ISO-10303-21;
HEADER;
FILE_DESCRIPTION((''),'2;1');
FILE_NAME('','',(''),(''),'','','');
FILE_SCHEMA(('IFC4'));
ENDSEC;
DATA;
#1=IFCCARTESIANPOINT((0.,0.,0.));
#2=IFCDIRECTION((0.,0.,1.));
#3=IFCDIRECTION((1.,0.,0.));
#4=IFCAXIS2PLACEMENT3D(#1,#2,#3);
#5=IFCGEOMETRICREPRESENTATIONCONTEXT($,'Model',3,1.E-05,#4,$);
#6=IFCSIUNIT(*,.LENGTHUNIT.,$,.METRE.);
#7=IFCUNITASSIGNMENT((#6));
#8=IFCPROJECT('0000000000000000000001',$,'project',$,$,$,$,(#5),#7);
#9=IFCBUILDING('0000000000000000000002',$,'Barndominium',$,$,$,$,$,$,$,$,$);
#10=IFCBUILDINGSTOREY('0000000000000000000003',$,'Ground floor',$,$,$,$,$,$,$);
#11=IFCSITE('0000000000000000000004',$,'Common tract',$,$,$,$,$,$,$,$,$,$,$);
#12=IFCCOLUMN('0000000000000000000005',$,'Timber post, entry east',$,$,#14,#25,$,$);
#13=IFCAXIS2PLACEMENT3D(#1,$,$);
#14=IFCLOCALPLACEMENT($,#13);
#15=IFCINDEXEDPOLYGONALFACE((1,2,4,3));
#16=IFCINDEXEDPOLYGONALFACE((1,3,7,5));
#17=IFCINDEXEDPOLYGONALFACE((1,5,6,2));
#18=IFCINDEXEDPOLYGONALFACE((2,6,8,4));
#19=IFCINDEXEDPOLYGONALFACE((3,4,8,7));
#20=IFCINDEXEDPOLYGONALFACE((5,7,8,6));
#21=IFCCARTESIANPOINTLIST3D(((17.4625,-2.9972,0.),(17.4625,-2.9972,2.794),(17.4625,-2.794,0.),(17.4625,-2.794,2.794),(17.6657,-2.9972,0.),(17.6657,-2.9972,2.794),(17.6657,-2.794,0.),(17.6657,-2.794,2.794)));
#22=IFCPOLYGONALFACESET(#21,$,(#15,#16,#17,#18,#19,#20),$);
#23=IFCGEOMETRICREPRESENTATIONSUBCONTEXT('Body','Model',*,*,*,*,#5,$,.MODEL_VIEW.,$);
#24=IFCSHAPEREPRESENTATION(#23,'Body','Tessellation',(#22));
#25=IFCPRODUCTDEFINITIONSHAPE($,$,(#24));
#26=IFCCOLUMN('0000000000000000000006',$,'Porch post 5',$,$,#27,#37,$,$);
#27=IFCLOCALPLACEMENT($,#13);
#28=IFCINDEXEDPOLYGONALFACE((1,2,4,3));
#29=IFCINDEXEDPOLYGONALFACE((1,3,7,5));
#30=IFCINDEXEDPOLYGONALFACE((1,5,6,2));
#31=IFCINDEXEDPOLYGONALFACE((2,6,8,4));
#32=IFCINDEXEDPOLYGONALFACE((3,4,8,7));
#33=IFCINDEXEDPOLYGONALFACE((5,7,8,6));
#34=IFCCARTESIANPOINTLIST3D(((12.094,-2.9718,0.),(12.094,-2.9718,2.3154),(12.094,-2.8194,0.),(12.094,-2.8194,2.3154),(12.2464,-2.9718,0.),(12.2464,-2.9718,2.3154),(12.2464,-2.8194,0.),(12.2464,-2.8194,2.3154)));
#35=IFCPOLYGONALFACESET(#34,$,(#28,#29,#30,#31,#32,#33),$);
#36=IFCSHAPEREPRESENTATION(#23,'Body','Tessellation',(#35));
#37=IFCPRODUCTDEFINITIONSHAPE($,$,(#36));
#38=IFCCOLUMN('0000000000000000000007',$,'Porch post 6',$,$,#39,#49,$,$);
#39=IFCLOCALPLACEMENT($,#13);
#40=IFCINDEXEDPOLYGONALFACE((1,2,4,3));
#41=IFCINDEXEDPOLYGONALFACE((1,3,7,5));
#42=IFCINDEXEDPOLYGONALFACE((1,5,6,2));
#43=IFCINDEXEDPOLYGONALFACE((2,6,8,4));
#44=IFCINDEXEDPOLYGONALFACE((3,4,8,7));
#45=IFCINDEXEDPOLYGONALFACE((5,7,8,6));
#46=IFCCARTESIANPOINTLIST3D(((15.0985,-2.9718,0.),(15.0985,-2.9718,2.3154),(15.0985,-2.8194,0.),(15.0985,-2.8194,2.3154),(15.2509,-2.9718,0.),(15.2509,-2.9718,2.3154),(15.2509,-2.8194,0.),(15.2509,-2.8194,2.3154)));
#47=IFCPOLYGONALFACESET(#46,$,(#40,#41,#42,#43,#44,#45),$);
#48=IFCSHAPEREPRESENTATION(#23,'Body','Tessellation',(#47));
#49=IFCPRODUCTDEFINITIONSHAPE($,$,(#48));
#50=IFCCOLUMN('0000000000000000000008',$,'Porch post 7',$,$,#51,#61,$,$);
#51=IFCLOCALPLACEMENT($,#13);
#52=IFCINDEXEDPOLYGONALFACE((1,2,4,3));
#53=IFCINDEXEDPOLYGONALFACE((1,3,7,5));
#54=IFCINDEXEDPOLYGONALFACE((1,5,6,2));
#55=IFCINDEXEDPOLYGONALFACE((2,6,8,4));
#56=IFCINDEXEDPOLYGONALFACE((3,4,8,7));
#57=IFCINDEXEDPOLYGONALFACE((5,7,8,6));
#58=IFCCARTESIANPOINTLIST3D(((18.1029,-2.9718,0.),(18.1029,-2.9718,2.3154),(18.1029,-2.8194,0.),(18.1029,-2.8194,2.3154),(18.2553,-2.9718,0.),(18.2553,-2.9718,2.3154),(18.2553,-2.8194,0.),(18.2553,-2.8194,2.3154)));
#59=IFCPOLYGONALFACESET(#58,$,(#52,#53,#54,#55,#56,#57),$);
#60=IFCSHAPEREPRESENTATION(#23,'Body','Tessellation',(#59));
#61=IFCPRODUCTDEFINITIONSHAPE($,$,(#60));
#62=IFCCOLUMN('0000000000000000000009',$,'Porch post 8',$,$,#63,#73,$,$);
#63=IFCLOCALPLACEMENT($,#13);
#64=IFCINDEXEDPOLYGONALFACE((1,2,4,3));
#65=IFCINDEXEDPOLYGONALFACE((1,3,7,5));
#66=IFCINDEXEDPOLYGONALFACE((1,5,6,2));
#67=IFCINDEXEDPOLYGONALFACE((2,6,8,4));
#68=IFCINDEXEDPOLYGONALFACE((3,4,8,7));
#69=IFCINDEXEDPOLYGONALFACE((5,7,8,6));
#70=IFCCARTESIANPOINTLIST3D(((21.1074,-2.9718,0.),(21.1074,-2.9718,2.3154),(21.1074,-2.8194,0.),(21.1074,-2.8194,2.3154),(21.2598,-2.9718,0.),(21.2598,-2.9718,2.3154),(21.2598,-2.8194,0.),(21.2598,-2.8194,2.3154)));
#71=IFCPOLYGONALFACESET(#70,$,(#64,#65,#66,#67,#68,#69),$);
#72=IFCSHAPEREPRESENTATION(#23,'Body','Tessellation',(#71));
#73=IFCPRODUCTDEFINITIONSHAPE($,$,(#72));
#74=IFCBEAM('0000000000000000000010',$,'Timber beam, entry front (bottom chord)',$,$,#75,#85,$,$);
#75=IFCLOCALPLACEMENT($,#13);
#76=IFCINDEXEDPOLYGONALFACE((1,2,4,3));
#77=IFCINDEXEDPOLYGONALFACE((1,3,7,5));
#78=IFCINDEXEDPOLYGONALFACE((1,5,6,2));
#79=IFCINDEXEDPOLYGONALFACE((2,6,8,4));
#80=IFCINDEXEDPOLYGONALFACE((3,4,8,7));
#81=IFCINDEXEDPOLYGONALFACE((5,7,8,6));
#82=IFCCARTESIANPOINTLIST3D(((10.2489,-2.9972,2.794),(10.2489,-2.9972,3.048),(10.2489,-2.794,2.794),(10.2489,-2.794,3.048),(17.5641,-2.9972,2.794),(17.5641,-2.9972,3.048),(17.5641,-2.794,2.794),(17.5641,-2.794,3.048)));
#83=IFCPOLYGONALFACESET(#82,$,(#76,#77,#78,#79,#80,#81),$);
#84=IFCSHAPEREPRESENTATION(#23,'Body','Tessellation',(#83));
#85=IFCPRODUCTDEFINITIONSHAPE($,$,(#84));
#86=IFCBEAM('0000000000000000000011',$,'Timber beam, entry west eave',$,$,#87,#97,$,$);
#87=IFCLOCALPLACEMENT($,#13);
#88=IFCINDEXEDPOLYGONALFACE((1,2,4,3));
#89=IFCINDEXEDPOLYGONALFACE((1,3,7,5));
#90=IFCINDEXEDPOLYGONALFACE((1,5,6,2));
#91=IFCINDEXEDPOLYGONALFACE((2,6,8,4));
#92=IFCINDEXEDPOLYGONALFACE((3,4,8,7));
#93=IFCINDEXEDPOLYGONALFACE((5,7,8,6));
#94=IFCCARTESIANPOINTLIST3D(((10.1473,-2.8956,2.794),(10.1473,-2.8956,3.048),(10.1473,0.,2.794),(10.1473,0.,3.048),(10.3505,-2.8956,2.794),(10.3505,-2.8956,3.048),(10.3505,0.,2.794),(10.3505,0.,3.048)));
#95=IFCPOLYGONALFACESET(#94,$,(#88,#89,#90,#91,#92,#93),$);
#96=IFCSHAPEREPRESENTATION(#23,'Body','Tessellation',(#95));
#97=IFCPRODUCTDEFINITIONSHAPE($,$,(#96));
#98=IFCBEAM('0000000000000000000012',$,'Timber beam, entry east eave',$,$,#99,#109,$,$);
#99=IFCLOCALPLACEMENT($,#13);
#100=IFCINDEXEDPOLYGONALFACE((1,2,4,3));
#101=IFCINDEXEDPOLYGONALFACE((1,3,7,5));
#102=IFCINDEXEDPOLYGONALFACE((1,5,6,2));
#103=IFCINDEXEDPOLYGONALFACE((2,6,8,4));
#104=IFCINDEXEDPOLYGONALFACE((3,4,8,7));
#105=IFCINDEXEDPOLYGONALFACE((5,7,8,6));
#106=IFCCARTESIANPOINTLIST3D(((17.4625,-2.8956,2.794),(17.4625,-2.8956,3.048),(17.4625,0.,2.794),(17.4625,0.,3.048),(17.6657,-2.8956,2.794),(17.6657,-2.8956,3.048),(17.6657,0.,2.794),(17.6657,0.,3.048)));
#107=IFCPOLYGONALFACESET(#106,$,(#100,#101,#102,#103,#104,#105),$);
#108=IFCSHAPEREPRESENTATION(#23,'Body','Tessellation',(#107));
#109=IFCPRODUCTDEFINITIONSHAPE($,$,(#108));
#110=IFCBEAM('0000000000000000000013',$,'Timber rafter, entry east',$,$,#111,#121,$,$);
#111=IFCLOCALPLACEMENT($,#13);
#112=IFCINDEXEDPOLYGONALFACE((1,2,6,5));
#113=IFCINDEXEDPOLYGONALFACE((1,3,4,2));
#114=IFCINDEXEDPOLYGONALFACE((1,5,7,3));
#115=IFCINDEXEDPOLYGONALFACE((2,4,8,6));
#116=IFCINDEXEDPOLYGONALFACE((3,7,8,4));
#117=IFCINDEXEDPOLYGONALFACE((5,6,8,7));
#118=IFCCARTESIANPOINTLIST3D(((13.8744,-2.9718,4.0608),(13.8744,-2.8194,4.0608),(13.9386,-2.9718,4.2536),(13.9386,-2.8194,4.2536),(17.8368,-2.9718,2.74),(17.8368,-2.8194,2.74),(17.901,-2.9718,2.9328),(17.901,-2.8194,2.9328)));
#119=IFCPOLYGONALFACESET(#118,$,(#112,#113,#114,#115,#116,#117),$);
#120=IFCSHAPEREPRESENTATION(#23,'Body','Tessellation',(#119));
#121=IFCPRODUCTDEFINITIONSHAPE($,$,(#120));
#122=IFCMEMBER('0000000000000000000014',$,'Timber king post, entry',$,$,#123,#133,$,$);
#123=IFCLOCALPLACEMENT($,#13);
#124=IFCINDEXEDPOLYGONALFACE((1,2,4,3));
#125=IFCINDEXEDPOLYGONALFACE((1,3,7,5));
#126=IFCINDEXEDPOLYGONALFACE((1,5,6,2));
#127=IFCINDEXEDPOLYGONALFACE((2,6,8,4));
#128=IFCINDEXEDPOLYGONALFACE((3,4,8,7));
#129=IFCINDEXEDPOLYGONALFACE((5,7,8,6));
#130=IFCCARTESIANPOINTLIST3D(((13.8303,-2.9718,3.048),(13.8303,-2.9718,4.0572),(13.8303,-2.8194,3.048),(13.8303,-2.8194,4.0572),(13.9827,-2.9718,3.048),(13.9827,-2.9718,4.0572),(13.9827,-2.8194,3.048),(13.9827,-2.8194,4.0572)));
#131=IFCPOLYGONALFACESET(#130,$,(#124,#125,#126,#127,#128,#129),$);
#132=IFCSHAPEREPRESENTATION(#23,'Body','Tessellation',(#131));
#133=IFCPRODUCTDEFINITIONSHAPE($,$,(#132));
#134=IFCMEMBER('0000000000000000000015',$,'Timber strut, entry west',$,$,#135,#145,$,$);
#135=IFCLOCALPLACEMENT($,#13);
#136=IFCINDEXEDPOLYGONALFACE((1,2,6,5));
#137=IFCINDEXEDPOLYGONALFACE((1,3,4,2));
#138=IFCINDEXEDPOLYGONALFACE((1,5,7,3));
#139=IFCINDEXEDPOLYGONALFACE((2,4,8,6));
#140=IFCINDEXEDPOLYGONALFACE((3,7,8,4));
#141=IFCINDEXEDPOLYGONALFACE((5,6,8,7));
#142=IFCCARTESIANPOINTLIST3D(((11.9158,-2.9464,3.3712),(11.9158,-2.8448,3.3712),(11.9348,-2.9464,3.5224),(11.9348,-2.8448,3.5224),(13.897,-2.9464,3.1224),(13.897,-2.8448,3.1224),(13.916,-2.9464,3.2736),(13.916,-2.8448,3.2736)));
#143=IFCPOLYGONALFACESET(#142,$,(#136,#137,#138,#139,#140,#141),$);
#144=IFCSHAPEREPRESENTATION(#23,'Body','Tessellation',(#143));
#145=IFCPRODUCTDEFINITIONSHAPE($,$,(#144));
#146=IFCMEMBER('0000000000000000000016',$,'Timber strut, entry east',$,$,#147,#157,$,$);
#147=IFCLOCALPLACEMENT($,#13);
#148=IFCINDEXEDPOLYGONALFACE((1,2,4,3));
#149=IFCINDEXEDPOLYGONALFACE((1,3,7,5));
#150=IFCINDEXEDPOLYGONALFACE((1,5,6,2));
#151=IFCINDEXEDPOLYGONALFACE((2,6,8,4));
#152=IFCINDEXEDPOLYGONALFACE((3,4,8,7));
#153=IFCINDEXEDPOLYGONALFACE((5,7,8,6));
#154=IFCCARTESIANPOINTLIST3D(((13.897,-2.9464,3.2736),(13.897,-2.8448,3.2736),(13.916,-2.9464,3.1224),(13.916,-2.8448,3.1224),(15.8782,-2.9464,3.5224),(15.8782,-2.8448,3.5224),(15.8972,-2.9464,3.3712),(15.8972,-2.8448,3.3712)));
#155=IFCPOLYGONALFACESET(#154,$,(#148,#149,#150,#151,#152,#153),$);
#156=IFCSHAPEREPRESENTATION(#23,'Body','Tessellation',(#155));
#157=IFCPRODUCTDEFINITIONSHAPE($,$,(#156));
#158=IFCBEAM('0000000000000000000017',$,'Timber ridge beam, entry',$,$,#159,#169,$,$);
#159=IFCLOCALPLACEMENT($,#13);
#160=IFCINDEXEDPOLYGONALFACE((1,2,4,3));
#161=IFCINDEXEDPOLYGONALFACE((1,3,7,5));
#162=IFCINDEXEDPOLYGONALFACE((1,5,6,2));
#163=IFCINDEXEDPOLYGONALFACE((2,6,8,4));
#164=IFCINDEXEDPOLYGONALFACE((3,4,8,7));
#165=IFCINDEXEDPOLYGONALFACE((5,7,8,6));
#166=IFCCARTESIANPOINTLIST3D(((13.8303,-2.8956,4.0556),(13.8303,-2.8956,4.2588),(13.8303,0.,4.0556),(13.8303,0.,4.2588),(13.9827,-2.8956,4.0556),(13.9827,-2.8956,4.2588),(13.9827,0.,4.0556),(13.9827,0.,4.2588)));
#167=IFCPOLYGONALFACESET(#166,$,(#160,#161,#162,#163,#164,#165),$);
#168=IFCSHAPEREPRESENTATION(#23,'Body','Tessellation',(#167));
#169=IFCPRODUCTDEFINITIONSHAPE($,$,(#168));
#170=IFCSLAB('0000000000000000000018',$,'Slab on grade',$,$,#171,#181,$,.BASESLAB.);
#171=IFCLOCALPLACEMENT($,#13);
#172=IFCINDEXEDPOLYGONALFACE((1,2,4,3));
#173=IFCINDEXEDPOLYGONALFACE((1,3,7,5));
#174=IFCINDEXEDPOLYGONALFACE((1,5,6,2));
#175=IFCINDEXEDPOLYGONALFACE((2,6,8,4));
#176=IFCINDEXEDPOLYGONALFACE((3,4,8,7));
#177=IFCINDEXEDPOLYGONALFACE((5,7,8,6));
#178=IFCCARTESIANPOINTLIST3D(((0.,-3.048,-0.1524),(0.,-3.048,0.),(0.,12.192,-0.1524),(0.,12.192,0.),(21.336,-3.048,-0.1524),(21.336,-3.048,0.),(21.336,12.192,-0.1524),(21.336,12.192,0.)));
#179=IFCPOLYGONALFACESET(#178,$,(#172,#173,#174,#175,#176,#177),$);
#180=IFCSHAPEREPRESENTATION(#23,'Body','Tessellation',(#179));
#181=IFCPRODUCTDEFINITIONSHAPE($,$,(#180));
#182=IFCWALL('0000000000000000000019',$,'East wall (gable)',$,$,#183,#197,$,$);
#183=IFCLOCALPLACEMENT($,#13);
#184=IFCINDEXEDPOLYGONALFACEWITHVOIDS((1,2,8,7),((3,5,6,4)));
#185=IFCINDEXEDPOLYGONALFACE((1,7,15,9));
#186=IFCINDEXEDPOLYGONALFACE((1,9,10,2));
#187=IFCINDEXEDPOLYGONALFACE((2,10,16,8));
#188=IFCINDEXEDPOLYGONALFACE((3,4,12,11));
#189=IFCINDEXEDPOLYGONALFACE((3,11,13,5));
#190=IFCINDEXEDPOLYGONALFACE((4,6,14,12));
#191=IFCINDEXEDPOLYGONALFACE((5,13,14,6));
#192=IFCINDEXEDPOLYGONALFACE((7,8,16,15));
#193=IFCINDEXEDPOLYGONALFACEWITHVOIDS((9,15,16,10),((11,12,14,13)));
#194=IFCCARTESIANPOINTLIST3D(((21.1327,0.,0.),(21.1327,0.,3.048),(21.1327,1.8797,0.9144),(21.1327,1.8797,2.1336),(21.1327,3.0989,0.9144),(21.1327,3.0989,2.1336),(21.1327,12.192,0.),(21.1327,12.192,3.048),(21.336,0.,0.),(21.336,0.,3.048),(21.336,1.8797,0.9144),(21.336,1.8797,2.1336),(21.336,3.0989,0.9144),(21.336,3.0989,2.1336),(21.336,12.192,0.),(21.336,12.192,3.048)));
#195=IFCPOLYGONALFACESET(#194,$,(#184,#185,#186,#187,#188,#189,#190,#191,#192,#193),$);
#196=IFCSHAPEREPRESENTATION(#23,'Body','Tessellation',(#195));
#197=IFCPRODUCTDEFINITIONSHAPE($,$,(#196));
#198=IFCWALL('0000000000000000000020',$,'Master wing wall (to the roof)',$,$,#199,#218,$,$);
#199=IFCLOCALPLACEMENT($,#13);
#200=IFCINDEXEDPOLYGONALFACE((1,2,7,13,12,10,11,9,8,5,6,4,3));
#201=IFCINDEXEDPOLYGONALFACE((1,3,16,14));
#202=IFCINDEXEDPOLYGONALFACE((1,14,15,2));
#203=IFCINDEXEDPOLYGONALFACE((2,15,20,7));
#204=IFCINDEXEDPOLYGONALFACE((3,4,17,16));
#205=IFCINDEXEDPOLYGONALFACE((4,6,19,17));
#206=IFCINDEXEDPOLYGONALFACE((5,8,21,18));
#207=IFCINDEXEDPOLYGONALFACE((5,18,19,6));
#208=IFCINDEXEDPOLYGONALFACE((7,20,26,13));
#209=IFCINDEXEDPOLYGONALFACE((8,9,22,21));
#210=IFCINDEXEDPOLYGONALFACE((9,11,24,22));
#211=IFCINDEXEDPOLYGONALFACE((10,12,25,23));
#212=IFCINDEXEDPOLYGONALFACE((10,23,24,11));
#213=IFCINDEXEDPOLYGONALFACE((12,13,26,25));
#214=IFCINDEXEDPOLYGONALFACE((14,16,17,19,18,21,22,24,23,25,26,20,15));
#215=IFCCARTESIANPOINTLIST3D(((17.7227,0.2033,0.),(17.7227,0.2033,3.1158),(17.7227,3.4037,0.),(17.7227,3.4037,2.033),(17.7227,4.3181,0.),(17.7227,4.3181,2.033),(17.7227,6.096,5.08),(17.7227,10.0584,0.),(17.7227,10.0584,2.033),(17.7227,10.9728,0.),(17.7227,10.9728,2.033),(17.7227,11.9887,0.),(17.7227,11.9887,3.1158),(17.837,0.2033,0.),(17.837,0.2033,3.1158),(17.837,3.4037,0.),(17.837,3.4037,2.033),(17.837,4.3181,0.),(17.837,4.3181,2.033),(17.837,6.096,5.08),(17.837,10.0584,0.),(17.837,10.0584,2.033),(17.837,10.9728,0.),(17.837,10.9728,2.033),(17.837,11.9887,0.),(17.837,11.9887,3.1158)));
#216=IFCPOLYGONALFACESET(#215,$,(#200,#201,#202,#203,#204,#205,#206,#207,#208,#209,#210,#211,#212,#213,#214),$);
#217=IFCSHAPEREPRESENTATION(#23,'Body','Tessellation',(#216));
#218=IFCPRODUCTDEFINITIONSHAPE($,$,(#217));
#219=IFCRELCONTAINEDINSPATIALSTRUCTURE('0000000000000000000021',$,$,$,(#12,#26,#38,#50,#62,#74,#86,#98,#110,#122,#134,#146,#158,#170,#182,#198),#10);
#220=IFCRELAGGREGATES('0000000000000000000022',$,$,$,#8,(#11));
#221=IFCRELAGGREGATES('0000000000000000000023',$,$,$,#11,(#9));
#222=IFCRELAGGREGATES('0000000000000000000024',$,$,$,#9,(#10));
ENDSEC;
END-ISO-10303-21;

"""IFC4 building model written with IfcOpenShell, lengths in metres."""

from ifc_helpers import new_model, si_unit, frame, origin_with_axes, place, context, subcontext, project, spatial, polyline, indexed_curve, rectangle, outline, extrude, element, save


model = new_model("IFC4")

# Units and contexts
model_context = context("Model", 3, precision=1e-05, world=origin_with_axes())
body_context = subcontext(model_context, "Body", "Model", "MODEL_VIEW")
ifc_project = project(units=[si_unit("LENGTHUNIT", "METRE")], contexts=[model_context])

# Site, building, storey
site = spatial("IfcSite", under=ifc_project, Name="Common tract")
building = spatial("IfcBuilding", under=site, Name="Barndominium")
storey = spatial("IfcBuildingStorey", under=building, Name="Ground floor")

# Columns
column_placement = place(None, frame((17.5641, -2.8956, 0.0), z_axis=(0.0, 0.0, 1.0), x_axis=(1.0, 0.0, 0.0)))
element("IfcColumn", 1, at=column_placement, inside=storey, Name="Timber post, entry east", context=body_context, shape_type="SweptSolid", body=[
    extrude(rectangle(XDim=0.2032, YDim=0.2032), origin_with_axes(), (0.0, 0.0, 1.0), 2.794),
])
for number, where, z_axis, x_axis, name in (
    (2, (12.1702, -2.8956, 0.0), (0.0, 0.0, 1.0), (1.0, 0.0, 0.0), "Porch post 5"),
    (3, (15.1747, -2.8956, 0.0), (0.0, 0.0, 1.0), (1.0, 0.0, 0.0), "Porch post 6"),
    (4, (18.1791, -2.8956, 0.0), (0.0, 0.0, 1.0), (1.0, 0.0, 0.0), "Porch post 7"),
    (5, (21.1836, -2.8956, 0.0), (0.0, 0.0, 1.0), (1.0, 0.0, 0.0), "Porch post 8"),
):
    element("IfcColumn", number, at=place(None, frame(where, z_axis=z_axis, x_axis=x_axis)), inside=storey, Name=name, context=body_context, shape_type="SweptSolid", body=[
        extrude(rectangle(XDim=0.1524, YDim=0.1524), origin_with_axes(), (0.0, 0.0, 1.0), 2.3154),
    ])

# Beams
beam_1_placement = place(None, frame((10.2489, -2.8956, 2.921), z_axis=(1.0, 0.0, 0.0), x_axis=(0.0, 1.0, 0.0)))
element("IfcBeam", 6, at=beam_1_placement, inside=storey, Name="Timber beam, entry front (bottom chord)", context=body_context, shape_type="SweptSolid", body=[
    extrude(rectangle(XDim=0.2032, YDim=0.254), origin_with_axes(), (0.0, 0.0, 1.0), 7.3152),
])
for number, where, z_axis, x_axis, name in (
    (7, (10.2489, -2.8956, 2.921), (0.0, 1.0, 0.0), (-1.0, 0.0, 0.0), "Timber beam, entry west eave"),
    (8, (17.5641, -2.8956, 2.921), (0.0, 1.0, 0.0), (-1.0, 0.0, 0.0), "Timber beam, entry east eave"),
):
    element("IfcBeam", number, at=place(None, frame(where, z_axis=z_axis, x_axis=x_axis)), inside=storey, Name=name, context=body_context, shape_type="SweptSolid", body=[
        extrude(rectangle(XDim=0.2032, YDim=0.254), origin_with_axes(), (0.0, 0.0, 1.0), 2.8956),
    ])
beam_2_placement = place(None, frame((17.8689, -2.8956, 2.8364), z_axis=(-0.948683, 0.0, 0.316228), x_axis=(0.0, -1.0, 0.0)))
element("IfcBeam", 9, at=beam_2_placement, inside=storey, Name="Timber rafter, entry east", context=body_context, shape_type="SweptSolid", body=[
    extrude(rectangle(XDim=0.1524, YDim=0.2032), origin_with_axes(), (0.0, 0.0, 1.0), 4.1767),
])

# Members
member_placement = place(None, frame((13.9065, -2.8956, 3.048), z_axis=(0.0, 0.0, 1.0), x_axis=(1.0, 0.0, 0.0)))
element("IfcMember", 10, at=member_placement, inside=storey, Name="Timber king post, entry", context=body_context, shape_type="SweptSolid", body=[
    extrude(rectangle(XDim=0.1524, YDim=0.1524), origin_with_axes(), (0.0, 0.0, 1.0), 1.0092),
])
for number, where, z_axis, x_axis, name in (
    (11, (13.9065, -2.8956, 3.198), (-0.992207, 0.0, 0.124602), (0.0, -1.0, 0.0), "Timber strut, entry west"),
    (12, (13.9065, -2.8956, 3.198), (0.992207, 0.0, 0.124602), (0.0, 1.0, 0.0), "Timber strut, entry east"),
):
    element("IfcMember", number, at=place(None, frame(where, z_axis=z_axis, x_axis=x_axis)), inside=storey, Name=name, context=body_context, shape_type="SweptSolid", body=[
        extrude(rectangle(XDim=0.1016, YDim=0.1524), origin_with_axes(), (0.0, 0.0, 1.0), 1.9968),
    ])

# Beam
beam_3_placement = place(None, frame((13.9065, -2.8956, 4.1572), z_axis=(0.0, 1.0, 0.0), x_axis=(-1.0, 0.0, 0.0)))
element("IfcBeam", 13, at=beam_3_placement, inside=storey, Name="Timber ridge beam, entry", context=body_context, shape_type="SweptSolid", body=[
    extrude(rectangle(XDim=0.1524, YDim=0.2032), origin_with_axes(), (0.0, 0.0, 1.0), 2.8956),
])

# Slab
slab_placement = place(None, frame((10.668, 4.572, -0.1524), z_axis=(0.0, 0.0, 1.0), x_axis=(1.0, 0.0, 0.0)))
element("IfcSlab", 14, at=slab_placement, inside=storey, Name="Slab on grade", PredefinedType="BASESLAB", context=body_context, shape_type="SweptSolid", body=[
    extrude(rectangle(XDim=21.336, YDim=15.24), origin_with_axes(), (0.0, 0.0, 1.0), 0.1524),
])

# Wall, opening
wall_1_placement = place(None, frame((21.336, 0.0, 0.0), z_axis=(0.0, 0.0, 1.0), x_axis=(0.0, 1.0, 0.0)))
wall_1 = element("IfcWall", 15, at=wall_1_placement, inside=storey, Name="East wall (gable)", context=body_context, shape_type="SweptSolid", body=[
    extrude(outline(indexed_curve([(0.0, 0.0), (0.0, 0.2033), (12.192, 0.2033), (12.192, 0.0), (0.0, 0.0)], self_intersect=False)), origin_with_axes(), (0.0, 0.0, 1.0), 3.048),
])
opening_1_placement = place(wall_1_placement, frame((2.4893, 0.1017, 0.9144), z_axis=(0.0, 0.0, 1.0), x_axis=(0.0, -1.0, 0.0)))
element("IfcOpeningElement", 16, at=opening_1_placement, cuts=wall_1, context=body_context, shape_type="SweptSolid", body=[
    extrude(rectangle(XDim=0.3033, YDim=1.2192), origin_with_axes(), (0.0, 0.0, 1.0), 1.2192),
])

# Wall, openings
wall_2_placement = place(None, frame((17.7227, 0.2033, 0.0), z_axis=(1.0, 0.0, 0.0), x_axis=(0.0, 1.0, 0.0)))
wall_2 = element("IfcWall", 17, at=wall_2_placement, inside=storey, Name="Master wing wall (to the roof)", context=body_context, shape_type="SweptSolid", body=[
    extrude(outline(polyline([(0.0, 0.0), (11.7854, 0.0), (11.7854, 3.1158), (5.8927, 5.08), (0.0, 3.1158), (0.0, 0.0)])), origin_with_axes(), (0.0, 0.0, 1.0), 0.1143),
])
opening_2_placement = place(wall_2_placement, frame((3.6576, 0.0, 0.0572), z_axis=(0.0, 1.0, 0.0), x_axis=(0.0, 0.0, 1.0)))
element("IfcOpeningElement", 18, at=opening_2_placement, cuts=wall_2, context=body_context, shape_type="SweptSolid", body=[
    extrude(rectangle(XDim=0.3033, YDim=0.9144), origin_with_axes(), (0.0, 0.0, 1.0), 2.033),
])
opening_3_placement = place(wall_2_placement, frame((10.3123, 0.0, 0.0572), z_axis=(0.0, 1.0, 0.0), x_axis=(0.0, 0.0, 1.0)))
element("IfcOpeningElement", 19, at=opening_3_placement, cuts=wall_2, context=body_context, shape_type="SweptSolid", body=[
    extrude(rectangle(XDim=0.3033, YDim=0.9144), origin_with_axes(), (0.0, 0.0, 1.0), 2.033),
])

save(model, "model.ifc")
